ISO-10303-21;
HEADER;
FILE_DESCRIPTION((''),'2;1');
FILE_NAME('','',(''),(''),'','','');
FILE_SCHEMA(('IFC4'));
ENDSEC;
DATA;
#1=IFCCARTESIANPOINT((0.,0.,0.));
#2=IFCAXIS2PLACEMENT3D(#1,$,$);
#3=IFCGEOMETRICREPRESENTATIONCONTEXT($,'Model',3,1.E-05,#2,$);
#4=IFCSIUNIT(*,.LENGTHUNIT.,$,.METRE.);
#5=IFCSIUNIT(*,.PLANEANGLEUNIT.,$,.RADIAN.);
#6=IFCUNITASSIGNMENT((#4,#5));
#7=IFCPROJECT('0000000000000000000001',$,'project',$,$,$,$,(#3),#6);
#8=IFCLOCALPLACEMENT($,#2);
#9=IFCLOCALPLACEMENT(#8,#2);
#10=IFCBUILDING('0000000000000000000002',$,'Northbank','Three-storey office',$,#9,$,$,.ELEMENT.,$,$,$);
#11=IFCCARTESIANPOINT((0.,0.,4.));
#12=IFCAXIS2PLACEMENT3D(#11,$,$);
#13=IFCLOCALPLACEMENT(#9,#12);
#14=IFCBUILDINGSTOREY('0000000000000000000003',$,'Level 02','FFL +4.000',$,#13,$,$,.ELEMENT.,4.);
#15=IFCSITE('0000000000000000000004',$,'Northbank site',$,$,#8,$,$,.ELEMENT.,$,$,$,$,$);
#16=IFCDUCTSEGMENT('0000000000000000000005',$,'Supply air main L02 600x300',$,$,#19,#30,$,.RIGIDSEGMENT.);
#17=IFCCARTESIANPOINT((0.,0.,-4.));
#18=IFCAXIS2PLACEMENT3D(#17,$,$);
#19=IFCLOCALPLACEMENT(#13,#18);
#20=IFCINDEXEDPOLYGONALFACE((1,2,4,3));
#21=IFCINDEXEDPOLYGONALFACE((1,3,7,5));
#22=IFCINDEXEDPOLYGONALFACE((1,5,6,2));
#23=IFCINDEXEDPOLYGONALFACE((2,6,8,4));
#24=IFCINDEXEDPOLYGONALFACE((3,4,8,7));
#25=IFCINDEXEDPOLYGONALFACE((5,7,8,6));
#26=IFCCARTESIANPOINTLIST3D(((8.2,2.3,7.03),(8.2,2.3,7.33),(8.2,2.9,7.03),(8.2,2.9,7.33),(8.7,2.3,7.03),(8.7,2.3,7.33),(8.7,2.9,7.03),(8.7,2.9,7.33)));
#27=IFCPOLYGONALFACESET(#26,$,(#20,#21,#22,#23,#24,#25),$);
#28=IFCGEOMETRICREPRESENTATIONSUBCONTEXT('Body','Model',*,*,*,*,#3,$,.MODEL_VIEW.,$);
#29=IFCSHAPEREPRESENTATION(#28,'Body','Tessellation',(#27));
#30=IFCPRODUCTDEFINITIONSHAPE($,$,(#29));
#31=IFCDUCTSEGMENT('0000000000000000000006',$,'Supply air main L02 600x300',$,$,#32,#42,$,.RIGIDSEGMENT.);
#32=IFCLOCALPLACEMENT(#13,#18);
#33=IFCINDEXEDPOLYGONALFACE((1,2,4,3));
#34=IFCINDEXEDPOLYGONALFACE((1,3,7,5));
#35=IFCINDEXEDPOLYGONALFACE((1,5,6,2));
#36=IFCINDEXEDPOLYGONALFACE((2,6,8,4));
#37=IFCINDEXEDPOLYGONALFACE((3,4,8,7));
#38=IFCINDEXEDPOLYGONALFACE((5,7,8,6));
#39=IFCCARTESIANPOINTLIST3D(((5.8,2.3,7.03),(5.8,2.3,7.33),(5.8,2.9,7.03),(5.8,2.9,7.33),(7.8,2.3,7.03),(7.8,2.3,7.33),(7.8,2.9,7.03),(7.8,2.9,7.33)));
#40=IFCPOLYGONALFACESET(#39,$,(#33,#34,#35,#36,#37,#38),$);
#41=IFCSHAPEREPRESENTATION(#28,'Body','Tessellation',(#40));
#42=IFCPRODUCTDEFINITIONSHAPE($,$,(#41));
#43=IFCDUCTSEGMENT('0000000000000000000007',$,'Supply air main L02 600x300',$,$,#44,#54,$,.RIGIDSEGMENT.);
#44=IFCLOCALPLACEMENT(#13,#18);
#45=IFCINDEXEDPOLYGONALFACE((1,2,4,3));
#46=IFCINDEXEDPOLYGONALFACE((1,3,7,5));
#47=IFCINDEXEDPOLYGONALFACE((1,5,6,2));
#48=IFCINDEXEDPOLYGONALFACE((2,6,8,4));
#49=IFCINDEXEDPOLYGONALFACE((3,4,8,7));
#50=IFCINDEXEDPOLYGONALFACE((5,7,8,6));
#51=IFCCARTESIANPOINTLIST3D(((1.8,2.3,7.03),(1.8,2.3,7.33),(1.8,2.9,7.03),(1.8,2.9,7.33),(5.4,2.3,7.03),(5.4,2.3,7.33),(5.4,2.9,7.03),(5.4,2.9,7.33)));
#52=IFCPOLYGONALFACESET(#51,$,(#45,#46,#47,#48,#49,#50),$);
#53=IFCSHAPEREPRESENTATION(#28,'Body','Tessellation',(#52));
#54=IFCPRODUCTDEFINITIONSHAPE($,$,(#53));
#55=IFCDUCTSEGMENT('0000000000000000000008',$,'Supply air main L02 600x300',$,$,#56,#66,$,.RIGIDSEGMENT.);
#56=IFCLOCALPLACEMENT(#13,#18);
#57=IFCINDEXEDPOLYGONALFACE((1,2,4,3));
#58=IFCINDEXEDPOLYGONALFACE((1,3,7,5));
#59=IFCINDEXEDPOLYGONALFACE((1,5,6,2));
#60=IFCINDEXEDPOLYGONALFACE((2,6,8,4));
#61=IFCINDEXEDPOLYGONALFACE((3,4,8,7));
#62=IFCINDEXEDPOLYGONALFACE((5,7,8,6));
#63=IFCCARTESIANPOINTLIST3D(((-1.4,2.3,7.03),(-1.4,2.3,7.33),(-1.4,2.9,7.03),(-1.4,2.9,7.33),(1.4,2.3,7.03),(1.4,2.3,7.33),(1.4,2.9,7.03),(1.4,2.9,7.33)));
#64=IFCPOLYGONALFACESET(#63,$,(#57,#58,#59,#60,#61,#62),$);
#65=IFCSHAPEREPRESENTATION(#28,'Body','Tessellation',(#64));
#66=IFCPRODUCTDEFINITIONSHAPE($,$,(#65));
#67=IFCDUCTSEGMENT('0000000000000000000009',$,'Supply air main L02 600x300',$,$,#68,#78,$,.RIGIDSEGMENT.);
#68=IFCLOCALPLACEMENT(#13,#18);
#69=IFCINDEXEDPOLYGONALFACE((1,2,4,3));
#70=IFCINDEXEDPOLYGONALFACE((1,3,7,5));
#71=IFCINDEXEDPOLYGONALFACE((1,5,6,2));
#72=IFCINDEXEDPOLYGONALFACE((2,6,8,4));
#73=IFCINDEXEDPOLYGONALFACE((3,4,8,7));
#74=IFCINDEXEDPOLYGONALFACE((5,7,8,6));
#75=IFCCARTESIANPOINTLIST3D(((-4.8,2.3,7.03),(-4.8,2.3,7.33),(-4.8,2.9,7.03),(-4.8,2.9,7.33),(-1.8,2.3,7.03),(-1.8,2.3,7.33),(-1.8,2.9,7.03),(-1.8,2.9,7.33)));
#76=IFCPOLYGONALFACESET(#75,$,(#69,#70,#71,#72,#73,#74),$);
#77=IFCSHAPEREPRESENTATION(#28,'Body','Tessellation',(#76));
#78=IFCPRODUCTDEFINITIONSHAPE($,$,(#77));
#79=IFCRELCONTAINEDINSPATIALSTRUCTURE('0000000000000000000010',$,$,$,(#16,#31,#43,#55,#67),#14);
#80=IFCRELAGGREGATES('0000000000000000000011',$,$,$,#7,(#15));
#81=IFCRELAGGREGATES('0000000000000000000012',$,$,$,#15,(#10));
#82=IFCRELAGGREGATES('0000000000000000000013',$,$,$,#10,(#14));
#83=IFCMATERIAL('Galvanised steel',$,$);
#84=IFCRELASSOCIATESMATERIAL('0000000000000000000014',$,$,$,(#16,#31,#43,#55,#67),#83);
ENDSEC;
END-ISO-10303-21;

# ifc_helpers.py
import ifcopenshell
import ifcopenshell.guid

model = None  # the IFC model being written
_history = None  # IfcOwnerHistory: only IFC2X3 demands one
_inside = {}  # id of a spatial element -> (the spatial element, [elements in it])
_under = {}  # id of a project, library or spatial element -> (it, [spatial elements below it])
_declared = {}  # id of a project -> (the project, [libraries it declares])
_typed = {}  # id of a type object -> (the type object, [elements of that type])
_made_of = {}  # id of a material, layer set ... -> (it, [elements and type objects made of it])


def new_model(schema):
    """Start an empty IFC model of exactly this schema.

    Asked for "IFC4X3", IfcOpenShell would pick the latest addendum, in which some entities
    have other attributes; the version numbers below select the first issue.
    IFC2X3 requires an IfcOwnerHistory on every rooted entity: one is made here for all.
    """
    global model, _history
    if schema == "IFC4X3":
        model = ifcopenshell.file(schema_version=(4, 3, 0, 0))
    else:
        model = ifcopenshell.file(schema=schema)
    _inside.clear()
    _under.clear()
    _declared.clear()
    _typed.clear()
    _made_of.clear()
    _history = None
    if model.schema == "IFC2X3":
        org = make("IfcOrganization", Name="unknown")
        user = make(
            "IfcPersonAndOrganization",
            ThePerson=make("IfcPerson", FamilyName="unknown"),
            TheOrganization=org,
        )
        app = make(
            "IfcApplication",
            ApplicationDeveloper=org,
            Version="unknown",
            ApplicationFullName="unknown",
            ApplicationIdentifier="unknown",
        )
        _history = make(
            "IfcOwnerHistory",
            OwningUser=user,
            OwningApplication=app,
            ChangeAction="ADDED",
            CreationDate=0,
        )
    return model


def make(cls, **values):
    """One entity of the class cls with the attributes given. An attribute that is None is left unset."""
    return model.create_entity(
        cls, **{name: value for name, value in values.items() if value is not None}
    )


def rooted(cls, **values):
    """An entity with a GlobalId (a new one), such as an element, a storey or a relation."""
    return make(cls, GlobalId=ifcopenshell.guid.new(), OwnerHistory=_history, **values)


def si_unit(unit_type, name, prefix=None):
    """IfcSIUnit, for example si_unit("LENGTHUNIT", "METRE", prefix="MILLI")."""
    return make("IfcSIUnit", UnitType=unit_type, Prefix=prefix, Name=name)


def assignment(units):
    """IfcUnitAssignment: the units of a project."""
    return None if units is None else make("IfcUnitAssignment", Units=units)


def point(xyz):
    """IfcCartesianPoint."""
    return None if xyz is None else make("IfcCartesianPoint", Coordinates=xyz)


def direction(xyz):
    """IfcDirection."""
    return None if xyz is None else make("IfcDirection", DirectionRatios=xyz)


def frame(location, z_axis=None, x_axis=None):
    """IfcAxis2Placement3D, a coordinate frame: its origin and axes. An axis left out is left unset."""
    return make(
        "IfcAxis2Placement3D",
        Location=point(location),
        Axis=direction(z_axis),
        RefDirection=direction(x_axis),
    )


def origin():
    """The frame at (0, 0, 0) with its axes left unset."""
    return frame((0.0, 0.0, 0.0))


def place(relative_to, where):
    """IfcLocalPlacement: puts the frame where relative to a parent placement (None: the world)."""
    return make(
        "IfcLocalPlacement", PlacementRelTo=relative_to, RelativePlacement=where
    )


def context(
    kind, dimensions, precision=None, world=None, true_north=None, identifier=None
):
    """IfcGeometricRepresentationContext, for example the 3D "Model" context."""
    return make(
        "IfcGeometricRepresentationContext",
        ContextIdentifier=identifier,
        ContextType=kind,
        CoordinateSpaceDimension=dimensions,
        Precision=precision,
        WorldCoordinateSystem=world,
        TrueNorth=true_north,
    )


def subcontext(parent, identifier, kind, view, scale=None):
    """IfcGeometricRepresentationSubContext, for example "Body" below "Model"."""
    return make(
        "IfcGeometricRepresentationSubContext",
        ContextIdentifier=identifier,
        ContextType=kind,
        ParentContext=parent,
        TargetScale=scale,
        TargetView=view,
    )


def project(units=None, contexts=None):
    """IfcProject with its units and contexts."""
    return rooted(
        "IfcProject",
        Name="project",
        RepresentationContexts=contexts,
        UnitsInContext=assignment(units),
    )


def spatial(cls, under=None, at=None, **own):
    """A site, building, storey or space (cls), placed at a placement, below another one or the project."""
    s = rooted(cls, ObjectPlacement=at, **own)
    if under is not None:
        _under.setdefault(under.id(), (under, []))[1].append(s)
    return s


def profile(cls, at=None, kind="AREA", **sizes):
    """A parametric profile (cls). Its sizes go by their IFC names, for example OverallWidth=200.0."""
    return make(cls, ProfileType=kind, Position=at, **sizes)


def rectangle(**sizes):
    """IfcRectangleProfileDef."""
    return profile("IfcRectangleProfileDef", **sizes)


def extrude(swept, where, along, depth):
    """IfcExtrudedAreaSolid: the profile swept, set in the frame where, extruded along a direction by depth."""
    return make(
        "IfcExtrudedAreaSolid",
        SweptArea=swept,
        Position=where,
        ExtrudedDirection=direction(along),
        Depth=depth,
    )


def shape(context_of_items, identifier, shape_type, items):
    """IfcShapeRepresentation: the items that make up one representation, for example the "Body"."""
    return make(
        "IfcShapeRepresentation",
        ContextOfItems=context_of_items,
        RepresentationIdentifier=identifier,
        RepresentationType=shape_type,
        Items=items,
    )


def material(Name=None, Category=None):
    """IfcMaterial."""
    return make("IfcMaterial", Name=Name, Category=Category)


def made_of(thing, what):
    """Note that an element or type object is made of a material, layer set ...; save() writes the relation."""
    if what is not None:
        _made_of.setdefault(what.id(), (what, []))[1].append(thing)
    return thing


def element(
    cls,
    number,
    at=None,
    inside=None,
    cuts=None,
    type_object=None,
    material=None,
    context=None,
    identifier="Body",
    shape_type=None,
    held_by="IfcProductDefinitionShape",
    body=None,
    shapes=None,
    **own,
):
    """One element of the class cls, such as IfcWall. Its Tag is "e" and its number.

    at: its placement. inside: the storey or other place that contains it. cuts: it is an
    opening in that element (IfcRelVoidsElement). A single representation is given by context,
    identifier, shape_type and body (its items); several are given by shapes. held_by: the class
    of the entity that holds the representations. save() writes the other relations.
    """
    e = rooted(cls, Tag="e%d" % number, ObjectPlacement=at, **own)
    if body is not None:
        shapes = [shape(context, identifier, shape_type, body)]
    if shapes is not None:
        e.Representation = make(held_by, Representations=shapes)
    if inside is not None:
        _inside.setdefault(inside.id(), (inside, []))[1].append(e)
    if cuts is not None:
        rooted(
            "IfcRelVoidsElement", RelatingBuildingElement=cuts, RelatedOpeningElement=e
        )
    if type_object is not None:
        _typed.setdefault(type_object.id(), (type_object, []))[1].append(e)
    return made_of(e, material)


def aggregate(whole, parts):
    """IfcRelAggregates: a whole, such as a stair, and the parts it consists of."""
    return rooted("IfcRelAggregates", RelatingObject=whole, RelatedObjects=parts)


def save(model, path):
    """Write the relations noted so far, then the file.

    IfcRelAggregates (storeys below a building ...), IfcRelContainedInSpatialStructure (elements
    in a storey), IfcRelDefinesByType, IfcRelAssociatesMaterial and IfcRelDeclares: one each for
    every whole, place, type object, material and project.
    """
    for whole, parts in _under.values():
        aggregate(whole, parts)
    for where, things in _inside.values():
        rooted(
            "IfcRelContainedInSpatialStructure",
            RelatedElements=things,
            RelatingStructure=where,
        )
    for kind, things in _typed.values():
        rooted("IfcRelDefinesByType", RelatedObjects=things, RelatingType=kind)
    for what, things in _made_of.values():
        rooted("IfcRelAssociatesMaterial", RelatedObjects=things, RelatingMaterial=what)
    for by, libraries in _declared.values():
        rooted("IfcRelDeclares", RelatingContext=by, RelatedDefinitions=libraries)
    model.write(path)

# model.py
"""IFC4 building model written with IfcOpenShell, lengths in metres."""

from ifc_helpers import new_model, si_unit, frame, origin, place, context, subcontext, project, spatial, rectangle, extrude, material, element, save


model = new_model("IFC4")

# Units and contexts
model_context = context("Model", 3, precision=1e-05, world=origin())
body_context = subcontext(model_context, "Body", "Model", "MODEL_VIEW")
ifc_project = project(units=[si_unit("LENGTHUNIT", "METRE"), si_unit("PLANEANGLEUNIT", "RADIAN")], contexts=[model_context])

# Site, building, storey
site_placement = place(None, origin())
site = spatial("IfcSite", under=ifc_project, at=site_placement, Name="Northbank site", CompositionType="ELEMENT")
building_placement = place(site_placement, origin())
building = spatial("IfcBuilding", under=site, at=building_placement, Name="Northbank", Description="Three-storey office", CompositionType="ELEMENT")
storey_placement = place(building_placement, frame((0.0, 0.0, 4.0)))
storey = spatial("IfcBuildingStorey", under=building, at=storey_placement, Name="Level 02", Description="FFL +4.000", CompositionType="ELEMENT", Elevation=4.0)

# Shared definitions
ifc_material = material(Name="Galvanised steel")

# Duct segment
duct_segment_1_placement = place(storey_placement, frame((0.0, 0.0, -4.0)))
element("IfcDuctSegment", 1, at=duct_segment_1_placement, inside=storey, material=ifc_material, Name="Supply air main L02 600x300", PredefinedType="RIGIDSEGMENT", context=body_context, shape_type="SweptSolid", body=[
    extrude(rectangle(XDim=0.6, YDim=0.3), frame((8.7, 2.6, 7.18), z_axis=(-1.0, 0.0, 0.0), x_axis=(0.0, -1.0, 0.0)), (0.0, 0.0, 1.0), 0.5),
])

# Duct segment
duct_segment_2_placement = place(storey_placement, frame((0.0, 0.0, -4.0)))
element("IfcDuctSegment", 2, at=duct_segment_2_placement, inside=storey, material=ifc_material, Name="Supply air main L02 600x300", PredefinedType="RIGIDSEGMENT", context=body_context, shape_type="SweptSolid", body=[
    extrude(rectangle(XDim=0.6, YDim=0.3), frame((7.8, 2.6, 7.18), z_axis=(-1.0, 0.0, 0.0), x_axis=(0.0, -1.0, 0.0)), (0.0, 0.0, 1.0), 2.0),
])

# Duct segment
duct_segment_3_placement = place(storey_placement, frame((0.0, 0.0, -4.0)))
element("IfcDuctSegment", 3, at=duct_segment_3_placement, inside=storey, material=ifc_material, Name="Supply air main L02 600x300", PredefinedType="RIGIDSEGMENT", context=body_context, shape_type="SweptSolid", body=[
    extrude(rectangle(XDim=0.6, YDim=0.3), frame((5.4, 2.6, 7.18), z_axis=(-1.0, 0.0, 0.0), x_axis=(0.0, -1.0, 0.0)), (0.0, 0.0, 1.0), 3.6),
])

# Duct segment
duct_segment_4_placement = place(storey_placement, frame((0.0, 0.0, -4.0)))
element("IfcDuctSegment", 4, at=duct_segment_4_placement, inside=storey, material=ifc_material, Name="Supply air main L02 600x300", PredefinedType="RIGIDSEGMENT", context=body_context, shape_type="SweptSolid", body=[
    extrude(rectangle(XDim=0.6, YDim=0.3), frame((1.4, 2.6, 7.18), z_axis=(-1.0, 0.0, 0.0), x_axis=(0.0, -1.0, 0.0)), (0.0, 0.0, 1.0), 2.8),
])

# Duct segment
duct_segment_5_placement = place(storey_placement, frame((0.0, 0.0, -4.0)))
element("IfcDuctSegment", 5, at=duct_segment_5_placement, inside=storey, material=ifc_material, Name="Supply air main L02 600x300", PredefinedType="RIGIDSEGMENT", context=body_context, shape_type="SweptSolid", body=[
    extrude(rectangle(XDim=0.6, YDim=0.3), frame((-1.8, 2.6, 7.18), z_axis=(-1.0, 0.0, 0.0), x_axis=(0.0, -1.0, 0.0)), (0.0, 0.0, 1.0), 3.0),
])

save(model, "model.ifc")
